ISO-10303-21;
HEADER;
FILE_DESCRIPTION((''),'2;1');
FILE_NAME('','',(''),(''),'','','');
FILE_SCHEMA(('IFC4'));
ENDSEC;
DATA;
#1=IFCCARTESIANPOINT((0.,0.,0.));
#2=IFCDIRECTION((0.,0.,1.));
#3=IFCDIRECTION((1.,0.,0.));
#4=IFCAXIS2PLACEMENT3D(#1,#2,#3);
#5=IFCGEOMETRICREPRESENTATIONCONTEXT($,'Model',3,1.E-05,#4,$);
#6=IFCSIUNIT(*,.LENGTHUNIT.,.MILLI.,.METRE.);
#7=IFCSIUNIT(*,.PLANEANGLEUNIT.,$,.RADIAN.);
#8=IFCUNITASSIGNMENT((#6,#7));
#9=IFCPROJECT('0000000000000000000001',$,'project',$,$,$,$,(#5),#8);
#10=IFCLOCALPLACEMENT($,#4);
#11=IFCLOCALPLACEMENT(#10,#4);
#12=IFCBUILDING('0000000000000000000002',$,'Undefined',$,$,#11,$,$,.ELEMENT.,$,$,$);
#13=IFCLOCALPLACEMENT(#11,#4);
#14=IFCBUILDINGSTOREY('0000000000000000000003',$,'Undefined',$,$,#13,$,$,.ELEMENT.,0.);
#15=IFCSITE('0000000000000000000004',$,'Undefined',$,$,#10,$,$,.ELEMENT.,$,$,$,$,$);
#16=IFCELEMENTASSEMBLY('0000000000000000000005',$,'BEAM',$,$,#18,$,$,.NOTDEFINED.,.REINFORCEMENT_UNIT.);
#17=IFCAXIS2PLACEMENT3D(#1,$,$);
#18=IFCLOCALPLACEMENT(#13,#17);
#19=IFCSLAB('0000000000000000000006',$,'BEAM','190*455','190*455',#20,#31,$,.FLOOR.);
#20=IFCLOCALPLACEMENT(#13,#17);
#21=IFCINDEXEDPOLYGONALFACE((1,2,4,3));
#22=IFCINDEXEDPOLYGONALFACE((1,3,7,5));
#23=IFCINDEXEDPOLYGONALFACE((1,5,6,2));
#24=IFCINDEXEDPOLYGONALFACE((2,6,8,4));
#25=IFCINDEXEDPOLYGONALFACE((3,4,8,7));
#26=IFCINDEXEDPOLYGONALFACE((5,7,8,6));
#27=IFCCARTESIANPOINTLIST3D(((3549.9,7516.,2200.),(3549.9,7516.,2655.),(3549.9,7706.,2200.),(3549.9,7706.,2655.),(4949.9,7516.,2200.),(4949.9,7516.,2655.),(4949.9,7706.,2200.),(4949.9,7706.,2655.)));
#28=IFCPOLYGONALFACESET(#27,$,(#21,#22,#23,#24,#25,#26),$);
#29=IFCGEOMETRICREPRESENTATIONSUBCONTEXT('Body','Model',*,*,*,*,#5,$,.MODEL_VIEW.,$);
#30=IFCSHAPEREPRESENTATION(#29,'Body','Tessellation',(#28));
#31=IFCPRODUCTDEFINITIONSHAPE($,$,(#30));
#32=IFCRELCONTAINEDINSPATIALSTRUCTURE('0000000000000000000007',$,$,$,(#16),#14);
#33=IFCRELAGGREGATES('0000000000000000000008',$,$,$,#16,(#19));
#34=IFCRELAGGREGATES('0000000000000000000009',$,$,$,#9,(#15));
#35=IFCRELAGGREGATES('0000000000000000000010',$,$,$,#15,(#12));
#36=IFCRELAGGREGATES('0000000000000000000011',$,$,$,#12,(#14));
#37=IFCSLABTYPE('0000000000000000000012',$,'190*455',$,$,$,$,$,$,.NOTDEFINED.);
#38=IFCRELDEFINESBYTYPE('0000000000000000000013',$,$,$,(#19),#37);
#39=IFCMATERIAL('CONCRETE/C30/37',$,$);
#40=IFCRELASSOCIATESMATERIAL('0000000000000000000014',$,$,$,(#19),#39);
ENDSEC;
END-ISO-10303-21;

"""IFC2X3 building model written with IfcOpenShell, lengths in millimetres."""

from ifc_helpers import new_model, si_unit, frame, origin_with_axes, place, context, subcontext, project, spatial, polyline, outline, extrude, material, type_object, element, aggregate, save


model = new_model("IFC2X3")

# Units and contexts
model_context = context("Model", 3, precision=1e-05, world=origin_with_axes())
body_context = subcontext(model_context, "Body", "Model", "MODEL_VIEW")
ifc_project = project(units=[si_unit("LENGTHUNIT", "METRE", prefix="MILLI"), si_unit("PLANEANGLEUNIT", "RADIAN")], contexts=[model_context])

# Site, building, storey
site_placement = place(None, origin_with_axes())
site = spatial("IfcSite", under=ifc_project, at=site_placement, Name="Undefined", CompositionType="ELEMENT")
building_placement = place(site_placement, origin_with_axes())
building = spatial("IfcBuilding", under=site, at=building_placement, Name="Undefined", CompositionType="ELEMENT")
storey_placement = place(building_placement, origin_with_axes())
storey = spatial("IfcBuildingStorey", under=building, at=storey_placement, Name="Undefined", CompositionType="ELEMENT", Elevation=0.0)

# Element assembly, slab
assembly_1_placement = place(storey_placement, origin_with_axes())
assembly_1 = element("IfcElementAssembly", 1, at=assembly_1_placement, inside=storey, Name="BEAM", AssemblyPlace="NOTDEFINED", PredefinedType="REINFORCEMENT_UNIT")
ifc_material_1 = material(Name="CONCRETE/C30/37")
slab_type = type_object("IfcSlabType", Name="190*455", PredefinedType="NOTDEFINED")
slab_placement = place(assembly_1_placement, frame((3549.9, 7611.0, 2200.0), z_axis=(0.0, 1.0, 0.0), x_axis=(0.0, 0.0, 1.0)))
slab = element("IfcSlab", 2, at=slab_placement, type_object=slab_type, material=ifc_material_1, Name="BEAM", Description="190*455", ObjectType="190*455", PredefinedType="FLOOR", context=body_context, shape_type="SweptSolid", body=[
    extrude(outline(polyline([(0.0, 0.0), (455.0, 0.0), (455.0, 1400.0), (0.0, 1400.0), (0.0, 0.0)])), frame((0.0, 0.0, -95.0), z_axis=(0.0, 0.0, 1.0), x_axis=(1.0, 0.0, 0.0)), (0.0, 0.0, 1.0), 190.0),
])

aggregate(assembly_1, [slab])

save(model, "model.ifc")
